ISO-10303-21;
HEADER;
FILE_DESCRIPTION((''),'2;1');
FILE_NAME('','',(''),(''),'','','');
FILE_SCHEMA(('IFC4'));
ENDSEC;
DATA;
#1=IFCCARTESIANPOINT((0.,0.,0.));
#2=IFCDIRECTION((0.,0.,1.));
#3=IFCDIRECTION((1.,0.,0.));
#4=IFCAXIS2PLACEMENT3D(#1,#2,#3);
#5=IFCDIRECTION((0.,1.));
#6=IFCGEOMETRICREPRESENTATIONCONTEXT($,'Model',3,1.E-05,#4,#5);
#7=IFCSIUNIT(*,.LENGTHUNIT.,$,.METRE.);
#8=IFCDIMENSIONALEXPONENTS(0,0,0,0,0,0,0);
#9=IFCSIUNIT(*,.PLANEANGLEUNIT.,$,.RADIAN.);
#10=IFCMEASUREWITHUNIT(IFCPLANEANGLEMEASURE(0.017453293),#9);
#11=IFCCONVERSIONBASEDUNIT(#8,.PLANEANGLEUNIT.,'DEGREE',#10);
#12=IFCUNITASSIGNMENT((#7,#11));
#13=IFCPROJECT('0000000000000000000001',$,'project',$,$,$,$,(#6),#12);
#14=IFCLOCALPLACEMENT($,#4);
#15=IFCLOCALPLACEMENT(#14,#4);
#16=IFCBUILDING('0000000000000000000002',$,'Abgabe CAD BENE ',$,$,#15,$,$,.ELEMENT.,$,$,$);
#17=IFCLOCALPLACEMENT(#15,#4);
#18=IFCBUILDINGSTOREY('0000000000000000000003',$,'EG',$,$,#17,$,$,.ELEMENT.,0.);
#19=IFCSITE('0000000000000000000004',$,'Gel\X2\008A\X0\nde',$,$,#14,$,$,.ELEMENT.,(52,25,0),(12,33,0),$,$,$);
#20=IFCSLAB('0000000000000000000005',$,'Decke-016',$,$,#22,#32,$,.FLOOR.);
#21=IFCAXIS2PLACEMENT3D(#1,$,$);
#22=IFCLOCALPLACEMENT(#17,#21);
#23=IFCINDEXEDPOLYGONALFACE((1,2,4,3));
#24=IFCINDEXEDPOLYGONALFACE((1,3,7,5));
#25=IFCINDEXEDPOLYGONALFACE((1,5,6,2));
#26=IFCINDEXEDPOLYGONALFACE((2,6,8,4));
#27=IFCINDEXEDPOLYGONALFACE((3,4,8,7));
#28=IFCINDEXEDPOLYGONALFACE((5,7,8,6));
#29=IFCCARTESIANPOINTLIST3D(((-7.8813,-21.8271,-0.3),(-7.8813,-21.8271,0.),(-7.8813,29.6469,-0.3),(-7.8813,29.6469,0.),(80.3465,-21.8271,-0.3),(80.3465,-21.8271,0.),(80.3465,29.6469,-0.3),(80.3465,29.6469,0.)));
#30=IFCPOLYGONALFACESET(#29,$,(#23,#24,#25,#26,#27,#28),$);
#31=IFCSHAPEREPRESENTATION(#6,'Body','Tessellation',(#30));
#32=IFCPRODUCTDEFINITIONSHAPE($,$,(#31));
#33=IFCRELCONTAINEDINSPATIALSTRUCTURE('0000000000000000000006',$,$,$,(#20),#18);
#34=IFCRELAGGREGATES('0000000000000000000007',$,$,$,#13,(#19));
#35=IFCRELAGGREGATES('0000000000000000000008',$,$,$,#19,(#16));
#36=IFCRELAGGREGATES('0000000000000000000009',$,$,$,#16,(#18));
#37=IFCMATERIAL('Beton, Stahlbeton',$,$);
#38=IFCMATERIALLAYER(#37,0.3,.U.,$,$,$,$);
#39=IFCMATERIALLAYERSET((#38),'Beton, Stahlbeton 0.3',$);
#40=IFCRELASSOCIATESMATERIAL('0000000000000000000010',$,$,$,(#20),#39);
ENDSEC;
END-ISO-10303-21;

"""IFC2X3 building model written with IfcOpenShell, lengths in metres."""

from ifc_helpers import new_model, entity, si_unit, converted_unit, direction, frame, origin_with_axes, place, context, project, spatial, polyline, outline, extrude, material, layer, layer_set, layer_usage, element, save


model = new_model("IFC2X3")

# Units and contexts
model_context = context("Model", 3, precision=1e-05, world=origin_with_axes(), true_north=direction((0.0, 1.0)))
ifc_project = project(units=[si_unit("LENGTHUNIT", "METRE"), converted_unit("PLANEANGLEUNIT", "DEGREE", entity("IfcPlaneAngleMeasure", 0.017453293), si_unit("PLANEANGLEUNIT", "RADIAN"), dimensions=[0, 0, 0, 0, 0, 0, 0])], contexts=[model_context])

# Site, building, storey
site_placement = place(None, origin_with_axes())
site = spatial("IfcSite", under=ifc_project, at=site_placement, Name="Gel\u008ande", CompositionType="ELEMENT", RefLatitude=(52, 25, 0), RefLongitude=(12, 33, 0))
building_placement = place(site_placement, origin_with_axes())
building = spatial("IfcBuilding", under=site, at=building_placement, Name="Abgabe CAD BENE ", CompositionType="ELEMENT")
storey_placement = place(building_placement, origin_with_axes())
storey = spatial("IfcBuildingStorey", under=building, at=storey_placement, Name="EG", CompositionType="ELEMENT", Elevation=0.0)

# Slab
ifc_material = material(Name="Beton, Stahlbeton")
ifc_layer = layer(ifc_material, 0.3, ventilated="UNKNOWN")
ifc_layer_set = layer_set([ifc_layer], Name="Beton, Stahlbeton 0.3")
ifc_layer_usage = layer_usage(ifc_layer_set, "AXIS3", "NEGATIVE", 0.3)
slab_placement = place(storey_placement, frame((-7.8813, 29.6469, -0.3), z_axis=(0.0, 0.0, 1.0), x_axis=(1.0, 0.0, 0.0)))
element("IfcSlab", 1, at=slab_placement, inside=storey, material=ifc_layer_usage, Name="Decke-016", PredefinedType="FLOOR", context=model_context, shape_type="SweptSolid", body=[
    extrude(outline(polyline([(0.0, 0.0), (0.0, -51.474), (88.2278, -51.474), (88.2278, 0.0), (0.0, 0.0)])), origin_with_axes(), (0.0, 0.0, 1.0), 0.3),
])

save(model, "model.ifc")
